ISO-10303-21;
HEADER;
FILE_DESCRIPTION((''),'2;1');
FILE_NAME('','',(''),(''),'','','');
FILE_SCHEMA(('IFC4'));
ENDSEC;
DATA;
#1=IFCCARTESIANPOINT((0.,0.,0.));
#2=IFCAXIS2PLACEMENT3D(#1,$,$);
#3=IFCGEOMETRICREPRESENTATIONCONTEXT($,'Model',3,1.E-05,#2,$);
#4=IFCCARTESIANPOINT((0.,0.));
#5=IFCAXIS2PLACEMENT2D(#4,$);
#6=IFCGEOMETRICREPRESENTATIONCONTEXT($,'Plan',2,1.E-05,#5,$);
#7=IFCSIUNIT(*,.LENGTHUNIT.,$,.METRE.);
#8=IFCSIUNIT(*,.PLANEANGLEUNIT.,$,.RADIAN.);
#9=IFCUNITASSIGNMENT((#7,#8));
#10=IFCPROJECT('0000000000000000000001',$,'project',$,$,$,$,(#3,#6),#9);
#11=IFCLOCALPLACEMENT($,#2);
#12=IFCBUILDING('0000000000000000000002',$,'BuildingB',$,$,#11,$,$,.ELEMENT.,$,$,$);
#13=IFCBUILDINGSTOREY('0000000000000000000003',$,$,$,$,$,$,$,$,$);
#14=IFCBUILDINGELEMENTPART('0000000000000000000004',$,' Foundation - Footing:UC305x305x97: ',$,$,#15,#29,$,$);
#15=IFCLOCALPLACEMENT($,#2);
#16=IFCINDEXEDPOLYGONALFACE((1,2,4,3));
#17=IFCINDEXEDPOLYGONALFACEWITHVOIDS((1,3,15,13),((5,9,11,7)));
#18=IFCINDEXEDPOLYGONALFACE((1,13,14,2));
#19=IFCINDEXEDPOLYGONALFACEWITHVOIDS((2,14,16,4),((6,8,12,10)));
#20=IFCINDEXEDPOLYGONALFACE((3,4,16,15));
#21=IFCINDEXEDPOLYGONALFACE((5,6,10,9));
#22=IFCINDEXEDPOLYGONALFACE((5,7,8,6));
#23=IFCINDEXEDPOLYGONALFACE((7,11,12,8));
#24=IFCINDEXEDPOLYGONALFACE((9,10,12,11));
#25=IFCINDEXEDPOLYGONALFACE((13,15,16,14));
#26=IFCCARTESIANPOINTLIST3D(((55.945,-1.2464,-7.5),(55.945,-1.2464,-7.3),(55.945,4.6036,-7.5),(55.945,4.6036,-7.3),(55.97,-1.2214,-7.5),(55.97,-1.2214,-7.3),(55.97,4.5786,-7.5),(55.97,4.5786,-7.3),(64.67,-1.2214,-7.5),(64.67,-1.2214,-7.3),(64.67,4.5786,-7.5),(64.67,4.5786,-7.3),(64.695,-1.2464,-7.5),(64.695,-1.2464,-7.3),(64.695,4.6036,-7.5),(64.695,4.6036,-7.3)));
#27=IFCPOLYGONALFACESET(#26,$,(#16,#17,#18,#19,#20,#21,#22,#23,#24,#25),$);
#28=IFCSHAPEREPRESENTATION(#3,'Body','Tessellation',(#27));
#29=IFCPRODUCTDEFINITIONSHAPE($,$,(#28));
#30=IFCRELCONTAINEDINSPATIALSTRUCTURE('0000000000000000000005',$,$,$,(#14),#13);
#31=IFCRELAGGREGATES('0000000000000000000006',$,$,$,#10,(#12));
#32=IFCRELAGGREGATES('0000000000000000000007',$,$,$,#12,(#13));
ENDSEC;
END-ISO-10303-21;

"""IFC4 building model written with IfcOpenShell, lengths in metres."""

from ifc_helpers import new_model, si_unit, origin, origin_2d, place, context, project, spatial, polyline, outline, extrude, element, save


model = new_model("IFC4")

# Units and contexts
model_context = context("Model", 3, precision=1e-05, world=origin())
plan_context = context("Plan", 2, precision=1e-05, world=origin_2d())
ifc_project = project(units=[si_unit("LENGTHUNIT", "METRE"), si_unit("PLANEANGLEUNIT", "RADIAN")], contexts=[model_context, plan_context])

# Building, storey
building_placement = place(None, origin())
building = spatial("IfcBuilding", under=ifc_project, at=building_placement, Name="BuildingB", CompositionType="ELEMENT")
storey = spatial("IfcBuildingStorey", under=building)

# Building element part, opening
building_element_part_1 = element("IfcBuildingElementPart", 1, inside=storey, Name=" Foundation - Footing:UC305x305x97: ", context=model_context, shape_type="SweptSolid", body=[
    extrude(outline(polyline([(55.945, -1.2464, -7.5), (64.695, -1.2464, -7.5), (64.695, 4.6036, -7.5), (55.945, 4.6036, -7.5), (55.945, -1.2464, -7.5)])), None, (0.0, 0.0, 1.0), 0.2),
])
element("IfcOpeningElement", 2, inside=storey, cuts=building_element_part_1, context=model_context, shape_type="SweptSolid", body=[
    extrude(outline(polyline([(55.97, -1.2214, -7.5), (64.67, -1.2214, -7.5), (64.67, 4.5786, -7.5), (55.97, 4.5786, -7.5), (55.97, -1.2214, -7.5)])), None, (0.0, 0.0, 1.0), 0.2),
])

save(model, "model.ifc")
